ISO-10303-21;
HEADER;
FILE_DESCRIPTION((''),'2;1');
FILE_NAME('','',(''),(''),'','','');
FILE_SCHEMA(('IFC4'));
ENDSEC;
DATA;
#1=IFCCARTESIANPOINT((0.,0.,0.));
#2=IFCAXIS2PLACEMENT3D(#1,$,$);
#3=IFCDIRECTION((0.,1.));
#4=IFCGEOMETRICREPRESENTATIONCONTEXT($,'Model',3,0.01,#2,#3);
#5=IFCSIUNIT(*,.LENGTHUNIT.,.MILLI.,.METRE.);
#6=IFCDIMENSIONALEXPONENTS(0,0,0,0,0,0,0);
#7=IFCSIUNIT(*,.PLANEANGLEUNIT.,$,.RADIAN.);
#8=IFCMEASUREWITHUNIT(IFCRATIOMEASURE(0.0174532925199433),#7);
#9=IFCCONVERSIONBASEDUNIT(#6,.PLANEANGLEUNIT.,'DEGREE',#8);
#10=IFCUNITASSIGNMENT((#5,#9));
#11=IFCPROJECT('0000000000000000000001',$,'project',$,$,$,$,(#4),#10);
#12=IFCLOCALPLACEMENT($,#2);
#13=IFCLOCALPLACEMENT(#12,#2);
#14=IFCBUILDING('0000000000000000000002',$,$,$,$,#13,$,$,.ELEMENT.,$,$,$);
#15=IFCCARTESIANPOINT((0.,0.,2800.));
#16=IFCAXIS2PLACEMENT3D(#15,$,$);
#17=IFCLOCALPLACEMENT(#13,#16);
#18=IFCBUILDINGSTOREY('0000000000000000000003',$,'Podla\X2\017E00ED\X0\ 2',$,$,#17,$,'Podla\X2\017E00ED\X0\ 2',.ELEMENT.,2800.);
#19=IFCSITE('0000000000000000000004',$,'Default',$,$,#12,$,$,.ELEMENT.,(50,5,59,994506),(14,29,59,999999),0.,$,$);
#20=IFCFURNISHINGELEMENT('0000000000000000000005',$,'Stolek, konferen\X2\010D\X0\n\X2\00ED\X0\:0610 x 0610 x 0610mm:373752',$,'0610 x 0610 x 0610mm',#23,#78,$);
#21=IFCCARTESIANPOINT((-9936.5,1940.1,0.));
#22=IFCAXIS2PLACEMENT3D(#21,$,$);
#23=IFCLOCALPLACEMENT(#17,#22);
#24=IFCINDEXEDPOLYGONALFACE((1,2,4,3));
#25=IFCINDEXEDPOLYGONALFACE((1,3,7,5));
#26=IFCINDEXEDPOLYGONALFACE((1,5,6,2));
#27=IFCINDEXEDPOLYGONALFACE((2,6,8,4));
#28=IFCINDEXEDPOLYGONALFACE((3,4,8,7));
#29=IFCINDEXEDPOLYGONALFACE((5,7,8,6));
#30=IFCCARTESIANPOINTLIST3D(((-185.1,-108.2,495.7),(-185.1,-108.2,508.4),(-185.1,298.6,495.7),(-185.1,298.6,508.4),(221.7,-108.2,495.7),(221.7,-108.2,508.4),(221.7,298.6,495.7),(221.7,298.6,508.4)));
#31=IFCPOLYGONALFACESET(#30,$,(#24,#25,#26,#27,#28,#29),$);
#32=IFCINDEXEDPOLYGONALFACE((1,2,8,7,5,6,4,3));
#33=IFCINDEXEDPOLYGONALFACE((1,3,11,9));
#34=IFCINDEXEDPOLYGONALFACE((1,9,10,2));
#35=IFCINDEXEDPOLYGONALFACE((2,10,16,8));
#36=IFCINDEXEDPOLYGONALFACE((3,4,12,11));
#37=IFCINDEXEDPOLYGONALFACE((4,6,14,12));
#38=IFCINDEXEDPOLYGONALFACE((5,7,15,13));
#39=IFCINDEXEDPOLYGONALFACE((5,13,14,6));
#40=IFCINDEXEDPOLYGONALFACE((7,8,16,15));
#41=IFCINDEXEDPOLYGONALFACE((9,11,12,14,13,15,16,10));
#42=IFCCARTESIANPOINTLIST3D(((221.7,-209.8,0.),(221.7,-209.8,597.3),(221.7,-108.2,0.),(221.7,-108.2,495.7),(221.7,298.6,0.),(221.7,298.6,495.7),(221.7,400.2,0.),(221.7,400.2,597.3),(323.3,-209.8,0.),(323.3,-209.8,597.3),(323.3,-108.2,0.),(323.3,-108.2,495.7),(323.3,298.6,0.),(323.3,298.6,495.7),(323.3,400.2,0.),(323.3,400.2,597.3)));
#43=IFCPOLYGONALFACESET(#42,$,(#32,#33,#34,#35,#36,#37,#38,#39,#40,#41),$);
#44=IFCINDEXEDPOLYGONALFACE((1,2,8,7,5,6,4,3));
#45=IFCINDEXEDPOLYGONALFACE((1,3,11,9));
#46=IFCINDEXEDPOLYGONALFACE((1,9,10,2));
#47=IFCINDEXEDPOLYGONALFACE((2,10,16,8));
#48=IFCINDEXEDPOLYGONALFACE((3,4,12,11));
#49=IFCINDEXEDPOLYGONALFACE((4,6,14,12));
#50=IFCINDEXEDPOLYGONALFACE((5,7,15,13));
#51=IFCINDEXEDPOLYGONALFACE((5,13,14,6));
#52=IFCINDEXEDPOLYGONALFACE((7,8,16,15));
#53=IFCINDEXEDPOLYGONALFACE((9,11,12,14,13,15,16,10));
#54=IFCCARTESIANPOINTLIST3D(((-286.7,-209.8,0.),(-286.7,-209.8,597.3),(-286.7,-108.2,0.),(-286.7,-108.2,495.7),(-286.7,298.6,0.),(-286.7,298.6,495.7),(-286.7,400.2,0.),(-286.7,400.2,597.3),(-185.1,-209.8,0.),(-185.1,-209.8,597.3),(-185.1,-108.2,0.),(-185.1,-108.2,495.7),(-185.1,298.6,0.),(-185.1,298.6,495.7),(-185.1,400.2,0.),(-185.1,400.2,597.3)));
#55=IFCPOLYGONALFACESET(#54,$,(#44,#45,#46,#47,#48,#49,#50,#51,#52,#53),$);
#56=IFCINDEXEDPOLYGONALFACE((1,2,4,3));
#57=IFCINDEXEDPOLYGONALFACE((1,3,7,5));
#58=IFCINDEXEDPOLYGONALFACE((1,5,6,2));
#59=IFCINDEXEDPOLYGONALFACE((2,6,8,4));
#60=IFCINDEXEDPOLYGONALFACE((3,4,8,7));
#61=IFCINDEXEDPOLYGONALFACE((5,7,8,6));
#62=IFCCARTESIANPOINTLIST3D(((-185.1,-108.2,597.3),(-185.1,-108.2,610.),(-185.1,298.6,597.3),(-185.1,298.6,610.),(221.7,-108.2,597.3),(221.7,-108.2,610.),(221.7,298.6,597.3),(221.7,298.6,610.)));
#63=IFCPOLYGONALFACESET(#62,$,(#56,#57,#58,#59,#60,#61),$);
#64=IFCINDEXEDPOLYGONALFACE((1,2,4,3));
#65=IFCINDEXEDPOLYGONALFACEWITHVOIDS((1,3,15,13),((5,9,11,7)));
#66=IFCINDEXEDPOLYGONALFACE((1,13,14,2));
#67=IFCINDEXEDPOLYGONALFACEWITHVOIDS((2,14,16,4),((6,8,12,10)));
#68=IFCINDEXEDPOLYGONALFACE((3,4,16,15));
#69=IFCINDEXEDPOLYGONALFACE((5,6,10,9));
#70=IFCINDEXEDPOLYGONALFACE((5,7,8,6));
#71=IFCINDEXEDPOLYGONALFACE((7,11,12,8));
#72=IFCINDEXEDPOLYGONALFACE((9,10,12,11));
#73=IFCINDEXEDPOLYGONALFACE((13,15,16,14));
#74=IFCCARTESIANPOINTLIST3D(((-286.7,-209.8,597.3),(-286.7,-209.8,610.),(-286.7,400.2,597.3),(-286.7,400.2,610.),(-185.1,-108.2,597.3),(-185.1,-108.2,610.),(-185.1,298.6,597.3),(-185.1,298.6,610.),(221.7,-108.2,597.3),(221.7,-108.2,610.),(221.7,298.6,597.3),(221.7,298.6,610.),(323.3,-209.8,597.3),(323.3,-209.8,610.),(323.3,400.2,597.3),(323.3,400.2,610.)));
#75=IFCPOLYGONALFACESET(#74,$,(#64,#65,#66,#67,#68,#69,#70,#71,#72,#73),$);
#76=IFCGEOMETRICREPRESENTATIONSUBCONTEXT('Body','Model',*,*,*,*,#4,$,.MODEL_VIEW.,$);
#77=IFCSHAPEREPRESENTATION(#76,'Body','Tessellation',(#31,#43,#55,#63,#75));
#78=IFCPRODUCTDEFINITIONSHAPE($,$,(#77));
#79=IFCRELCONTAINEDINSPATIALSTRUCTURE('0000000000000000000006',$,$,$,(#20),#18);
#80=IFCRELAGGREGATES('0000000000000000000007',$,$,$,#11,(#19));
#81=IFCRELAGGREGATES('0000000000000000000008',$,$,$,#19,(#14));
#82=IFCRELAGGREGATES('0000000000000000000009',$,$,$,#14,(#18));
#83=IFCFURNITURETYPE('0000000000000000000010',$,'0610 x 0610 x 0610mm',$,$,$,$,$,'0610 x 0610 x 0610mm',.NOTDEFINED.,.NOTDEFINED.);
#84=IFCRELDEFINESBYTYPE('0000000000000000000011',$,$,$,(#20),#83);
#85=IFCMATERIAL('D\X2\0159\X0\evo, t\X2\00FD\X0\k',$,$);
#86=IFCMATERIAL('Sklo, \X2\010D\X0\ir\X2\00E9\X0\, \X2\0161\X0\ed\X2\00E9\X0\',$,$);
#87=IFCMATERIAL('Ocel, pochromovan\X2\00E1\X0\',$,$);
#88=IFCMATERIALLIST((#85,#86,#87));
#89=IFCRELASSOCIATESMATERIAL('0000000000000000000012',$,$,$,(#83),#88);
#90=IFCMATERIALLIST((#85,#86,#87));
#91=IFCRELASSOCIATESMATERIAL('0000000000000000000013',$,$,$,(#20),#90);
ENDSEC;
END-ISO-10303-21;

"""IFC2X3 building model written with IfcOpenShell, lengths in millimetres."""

from ifc_helpers import new_model, entity, si_unit, converted_unit, direction, frame, origin, origin_2d_with_axis, place, context, subcontext, project, spatial, polyline, rectangle, outline, extrude, source, transform, mapped, material, material_list, type_object, type_shapes, element, save


model = new_model("IFC2X3")

# Units and contexts
model_context = context("Model", 3, precision=0.01, world=origin(), true_north=direction((0.0, 1.0)))
body_context = subcontext(model_context, "Body", "Model", "MODEL_VIEW")
ifc_project = project(units=[si_unit("LENGTHUNIT", "METRE", prefix="MILLI"), converted_unit("PLANEANGLEUNIT", "DEGREE", entity("IfcRatioMeasure", 0.0174532925199433), si_unit("PLANEANGLEUNIT", "RADIAN"), dimensions=[0, 0, 0, 0, 0, 0, 0])], contexts=[model_context])

# Site, building, storey
site_placement = place(None, origin())
site = spatial("IfcSite", under=ifc_project, at=site_placement, Name="Default", CompositionType="ELEMENT", RefLatitude=(50, 5, 59, 994506), RefLongitude=(14, 29, 59, 999999), RefElevation=0.0)
building_placement = place(site_placement, origin())
building = spatial("IfcBuilding", under=site, at=building_placement, CompositionType="ELEMENT")
storey_placement = place(building_placement, frame((0.0, 0.0, 2800.0)))
storey = spatial("IfcBuildingStorey", under=building, at=storey_placement, Name="Podlaží 2", LongName="Podlaží 2", CompositionType="ELEMENT", Elevation=2800.0)

# Furnishing element
ifc_material_1 = material(Name="Ocel, pochromovaná")
ifc_material_2 = material(Name="Dřevo, týk")
ifc_material_3 = material(Name="Sklo, čiré, šedé")
ifc_material_list_1 = material_list([ifc_material_2, ifc_material_3, ifc_material_1])
ifc_material_list_2 = material_list([ifc_material_2, ifc_material_3, ifc_material_1])
furniture_type_1 = type_object("IfcFurnitureType", Name="0610 x 0610 x 0610mm", ElementType="0610 x 0610 x 0610mm", AssemblyPlace="NOTDEFINED", material=ifc_material_list_2)
shared_shape_1 = source(origin(), body_context, "Body", "SweptSolid", [
    extrude(rectangle(XDim=406.8, YDim=406.8, at=origin_2d_with_axis()), frame((18.3, 95.2, 495.7), z_axis=(0.0, 0.0, 1.0), x_axis=(-1.0, 0.0, 0.0)), (0.0, 0.0, 1.0), 12.7),
    extrude(outline(polyline([(-273.2, -305.0), (324.0, -305.0), (324.0, 305.0), (-273.2, 305.0), (-273.2, 203.4), (222.5, 203.4), (222.5, -203.4), (-273.2, -203.4), (-273.2, -305.0)])), frame((221.7, 95.2, 273.2), z_axis=(1.0, 0.0, 0.0), x_axis=(0.0, 0.0, 1.0)), (0.0, 0.0, 1.0), 101.6),
    extrude(outline(polyline([(-305.0, -324.1), (305.0, -324.1), (305.0, 273.3), (203.4, 273.3), (203.4, -222.4), (-203.4, -222.4), (-203.4, 273.3), (-305.0, 273.3), (-305.0, -324.1)])), frame((-286.7, 95.2, 273.3), z_axis=(1.0, 0.0, 0.0), x_axis=(0.0, -1.0, 0.0)), (0.0, 0.0, 1.0), 101.6),
    extrude(rectangle(XDim=406.8, YDim=406.8, at=origin_2d_with_axis()), frame((18.3, 95.2, 597.3), z_axis=(0.0, 0.0, 1.0), x_axis=(-1.0, 0.0, 0.0)), (0.0, 0.0, 1.0), 12.7),
    extrude(outline(polyline([(-305.0, -305.0), (305.0, -305.0), (305.0, 305.0), (-305.0, 305.0), (-305.0, -305.0)]), holes=[polyline([(-203.4, -203.4), (-203.4, 203.4), (203.4, 203.4), (203.4, -203.4), (-203.4, -203.4)])]), frame((18.3, 95.2, 597.3), z_axis=(0.0, 0.0, 1.0), x_axis=(-1.0, 0.0, 0.0)), (0.0, 0.0, 1.0), 12.7),
])
type_shapes(furniture_type_1, [shared_shape_1])
furnishing_1_placement = place(storey_placement, frame((-9936.5, 1940.1, 0.0)))
element("IfcFurnishingElement", 1, at=furnishing_1_placement, inside=storey, type_object=furniture_type_1, material=ifc_material_list_1, Name="Stolek, konferenční:0610 x 0610 x 0610mm:373752", ObjectType="0610 x 0610 x 0610mm", context=body_context, shape_type="MappedRepresentation", body=[
    mapped(shared_shape_1, transform((0.0, 0.0, 0.0), scale=1.0)),
])

save(model, "model.ifc")
